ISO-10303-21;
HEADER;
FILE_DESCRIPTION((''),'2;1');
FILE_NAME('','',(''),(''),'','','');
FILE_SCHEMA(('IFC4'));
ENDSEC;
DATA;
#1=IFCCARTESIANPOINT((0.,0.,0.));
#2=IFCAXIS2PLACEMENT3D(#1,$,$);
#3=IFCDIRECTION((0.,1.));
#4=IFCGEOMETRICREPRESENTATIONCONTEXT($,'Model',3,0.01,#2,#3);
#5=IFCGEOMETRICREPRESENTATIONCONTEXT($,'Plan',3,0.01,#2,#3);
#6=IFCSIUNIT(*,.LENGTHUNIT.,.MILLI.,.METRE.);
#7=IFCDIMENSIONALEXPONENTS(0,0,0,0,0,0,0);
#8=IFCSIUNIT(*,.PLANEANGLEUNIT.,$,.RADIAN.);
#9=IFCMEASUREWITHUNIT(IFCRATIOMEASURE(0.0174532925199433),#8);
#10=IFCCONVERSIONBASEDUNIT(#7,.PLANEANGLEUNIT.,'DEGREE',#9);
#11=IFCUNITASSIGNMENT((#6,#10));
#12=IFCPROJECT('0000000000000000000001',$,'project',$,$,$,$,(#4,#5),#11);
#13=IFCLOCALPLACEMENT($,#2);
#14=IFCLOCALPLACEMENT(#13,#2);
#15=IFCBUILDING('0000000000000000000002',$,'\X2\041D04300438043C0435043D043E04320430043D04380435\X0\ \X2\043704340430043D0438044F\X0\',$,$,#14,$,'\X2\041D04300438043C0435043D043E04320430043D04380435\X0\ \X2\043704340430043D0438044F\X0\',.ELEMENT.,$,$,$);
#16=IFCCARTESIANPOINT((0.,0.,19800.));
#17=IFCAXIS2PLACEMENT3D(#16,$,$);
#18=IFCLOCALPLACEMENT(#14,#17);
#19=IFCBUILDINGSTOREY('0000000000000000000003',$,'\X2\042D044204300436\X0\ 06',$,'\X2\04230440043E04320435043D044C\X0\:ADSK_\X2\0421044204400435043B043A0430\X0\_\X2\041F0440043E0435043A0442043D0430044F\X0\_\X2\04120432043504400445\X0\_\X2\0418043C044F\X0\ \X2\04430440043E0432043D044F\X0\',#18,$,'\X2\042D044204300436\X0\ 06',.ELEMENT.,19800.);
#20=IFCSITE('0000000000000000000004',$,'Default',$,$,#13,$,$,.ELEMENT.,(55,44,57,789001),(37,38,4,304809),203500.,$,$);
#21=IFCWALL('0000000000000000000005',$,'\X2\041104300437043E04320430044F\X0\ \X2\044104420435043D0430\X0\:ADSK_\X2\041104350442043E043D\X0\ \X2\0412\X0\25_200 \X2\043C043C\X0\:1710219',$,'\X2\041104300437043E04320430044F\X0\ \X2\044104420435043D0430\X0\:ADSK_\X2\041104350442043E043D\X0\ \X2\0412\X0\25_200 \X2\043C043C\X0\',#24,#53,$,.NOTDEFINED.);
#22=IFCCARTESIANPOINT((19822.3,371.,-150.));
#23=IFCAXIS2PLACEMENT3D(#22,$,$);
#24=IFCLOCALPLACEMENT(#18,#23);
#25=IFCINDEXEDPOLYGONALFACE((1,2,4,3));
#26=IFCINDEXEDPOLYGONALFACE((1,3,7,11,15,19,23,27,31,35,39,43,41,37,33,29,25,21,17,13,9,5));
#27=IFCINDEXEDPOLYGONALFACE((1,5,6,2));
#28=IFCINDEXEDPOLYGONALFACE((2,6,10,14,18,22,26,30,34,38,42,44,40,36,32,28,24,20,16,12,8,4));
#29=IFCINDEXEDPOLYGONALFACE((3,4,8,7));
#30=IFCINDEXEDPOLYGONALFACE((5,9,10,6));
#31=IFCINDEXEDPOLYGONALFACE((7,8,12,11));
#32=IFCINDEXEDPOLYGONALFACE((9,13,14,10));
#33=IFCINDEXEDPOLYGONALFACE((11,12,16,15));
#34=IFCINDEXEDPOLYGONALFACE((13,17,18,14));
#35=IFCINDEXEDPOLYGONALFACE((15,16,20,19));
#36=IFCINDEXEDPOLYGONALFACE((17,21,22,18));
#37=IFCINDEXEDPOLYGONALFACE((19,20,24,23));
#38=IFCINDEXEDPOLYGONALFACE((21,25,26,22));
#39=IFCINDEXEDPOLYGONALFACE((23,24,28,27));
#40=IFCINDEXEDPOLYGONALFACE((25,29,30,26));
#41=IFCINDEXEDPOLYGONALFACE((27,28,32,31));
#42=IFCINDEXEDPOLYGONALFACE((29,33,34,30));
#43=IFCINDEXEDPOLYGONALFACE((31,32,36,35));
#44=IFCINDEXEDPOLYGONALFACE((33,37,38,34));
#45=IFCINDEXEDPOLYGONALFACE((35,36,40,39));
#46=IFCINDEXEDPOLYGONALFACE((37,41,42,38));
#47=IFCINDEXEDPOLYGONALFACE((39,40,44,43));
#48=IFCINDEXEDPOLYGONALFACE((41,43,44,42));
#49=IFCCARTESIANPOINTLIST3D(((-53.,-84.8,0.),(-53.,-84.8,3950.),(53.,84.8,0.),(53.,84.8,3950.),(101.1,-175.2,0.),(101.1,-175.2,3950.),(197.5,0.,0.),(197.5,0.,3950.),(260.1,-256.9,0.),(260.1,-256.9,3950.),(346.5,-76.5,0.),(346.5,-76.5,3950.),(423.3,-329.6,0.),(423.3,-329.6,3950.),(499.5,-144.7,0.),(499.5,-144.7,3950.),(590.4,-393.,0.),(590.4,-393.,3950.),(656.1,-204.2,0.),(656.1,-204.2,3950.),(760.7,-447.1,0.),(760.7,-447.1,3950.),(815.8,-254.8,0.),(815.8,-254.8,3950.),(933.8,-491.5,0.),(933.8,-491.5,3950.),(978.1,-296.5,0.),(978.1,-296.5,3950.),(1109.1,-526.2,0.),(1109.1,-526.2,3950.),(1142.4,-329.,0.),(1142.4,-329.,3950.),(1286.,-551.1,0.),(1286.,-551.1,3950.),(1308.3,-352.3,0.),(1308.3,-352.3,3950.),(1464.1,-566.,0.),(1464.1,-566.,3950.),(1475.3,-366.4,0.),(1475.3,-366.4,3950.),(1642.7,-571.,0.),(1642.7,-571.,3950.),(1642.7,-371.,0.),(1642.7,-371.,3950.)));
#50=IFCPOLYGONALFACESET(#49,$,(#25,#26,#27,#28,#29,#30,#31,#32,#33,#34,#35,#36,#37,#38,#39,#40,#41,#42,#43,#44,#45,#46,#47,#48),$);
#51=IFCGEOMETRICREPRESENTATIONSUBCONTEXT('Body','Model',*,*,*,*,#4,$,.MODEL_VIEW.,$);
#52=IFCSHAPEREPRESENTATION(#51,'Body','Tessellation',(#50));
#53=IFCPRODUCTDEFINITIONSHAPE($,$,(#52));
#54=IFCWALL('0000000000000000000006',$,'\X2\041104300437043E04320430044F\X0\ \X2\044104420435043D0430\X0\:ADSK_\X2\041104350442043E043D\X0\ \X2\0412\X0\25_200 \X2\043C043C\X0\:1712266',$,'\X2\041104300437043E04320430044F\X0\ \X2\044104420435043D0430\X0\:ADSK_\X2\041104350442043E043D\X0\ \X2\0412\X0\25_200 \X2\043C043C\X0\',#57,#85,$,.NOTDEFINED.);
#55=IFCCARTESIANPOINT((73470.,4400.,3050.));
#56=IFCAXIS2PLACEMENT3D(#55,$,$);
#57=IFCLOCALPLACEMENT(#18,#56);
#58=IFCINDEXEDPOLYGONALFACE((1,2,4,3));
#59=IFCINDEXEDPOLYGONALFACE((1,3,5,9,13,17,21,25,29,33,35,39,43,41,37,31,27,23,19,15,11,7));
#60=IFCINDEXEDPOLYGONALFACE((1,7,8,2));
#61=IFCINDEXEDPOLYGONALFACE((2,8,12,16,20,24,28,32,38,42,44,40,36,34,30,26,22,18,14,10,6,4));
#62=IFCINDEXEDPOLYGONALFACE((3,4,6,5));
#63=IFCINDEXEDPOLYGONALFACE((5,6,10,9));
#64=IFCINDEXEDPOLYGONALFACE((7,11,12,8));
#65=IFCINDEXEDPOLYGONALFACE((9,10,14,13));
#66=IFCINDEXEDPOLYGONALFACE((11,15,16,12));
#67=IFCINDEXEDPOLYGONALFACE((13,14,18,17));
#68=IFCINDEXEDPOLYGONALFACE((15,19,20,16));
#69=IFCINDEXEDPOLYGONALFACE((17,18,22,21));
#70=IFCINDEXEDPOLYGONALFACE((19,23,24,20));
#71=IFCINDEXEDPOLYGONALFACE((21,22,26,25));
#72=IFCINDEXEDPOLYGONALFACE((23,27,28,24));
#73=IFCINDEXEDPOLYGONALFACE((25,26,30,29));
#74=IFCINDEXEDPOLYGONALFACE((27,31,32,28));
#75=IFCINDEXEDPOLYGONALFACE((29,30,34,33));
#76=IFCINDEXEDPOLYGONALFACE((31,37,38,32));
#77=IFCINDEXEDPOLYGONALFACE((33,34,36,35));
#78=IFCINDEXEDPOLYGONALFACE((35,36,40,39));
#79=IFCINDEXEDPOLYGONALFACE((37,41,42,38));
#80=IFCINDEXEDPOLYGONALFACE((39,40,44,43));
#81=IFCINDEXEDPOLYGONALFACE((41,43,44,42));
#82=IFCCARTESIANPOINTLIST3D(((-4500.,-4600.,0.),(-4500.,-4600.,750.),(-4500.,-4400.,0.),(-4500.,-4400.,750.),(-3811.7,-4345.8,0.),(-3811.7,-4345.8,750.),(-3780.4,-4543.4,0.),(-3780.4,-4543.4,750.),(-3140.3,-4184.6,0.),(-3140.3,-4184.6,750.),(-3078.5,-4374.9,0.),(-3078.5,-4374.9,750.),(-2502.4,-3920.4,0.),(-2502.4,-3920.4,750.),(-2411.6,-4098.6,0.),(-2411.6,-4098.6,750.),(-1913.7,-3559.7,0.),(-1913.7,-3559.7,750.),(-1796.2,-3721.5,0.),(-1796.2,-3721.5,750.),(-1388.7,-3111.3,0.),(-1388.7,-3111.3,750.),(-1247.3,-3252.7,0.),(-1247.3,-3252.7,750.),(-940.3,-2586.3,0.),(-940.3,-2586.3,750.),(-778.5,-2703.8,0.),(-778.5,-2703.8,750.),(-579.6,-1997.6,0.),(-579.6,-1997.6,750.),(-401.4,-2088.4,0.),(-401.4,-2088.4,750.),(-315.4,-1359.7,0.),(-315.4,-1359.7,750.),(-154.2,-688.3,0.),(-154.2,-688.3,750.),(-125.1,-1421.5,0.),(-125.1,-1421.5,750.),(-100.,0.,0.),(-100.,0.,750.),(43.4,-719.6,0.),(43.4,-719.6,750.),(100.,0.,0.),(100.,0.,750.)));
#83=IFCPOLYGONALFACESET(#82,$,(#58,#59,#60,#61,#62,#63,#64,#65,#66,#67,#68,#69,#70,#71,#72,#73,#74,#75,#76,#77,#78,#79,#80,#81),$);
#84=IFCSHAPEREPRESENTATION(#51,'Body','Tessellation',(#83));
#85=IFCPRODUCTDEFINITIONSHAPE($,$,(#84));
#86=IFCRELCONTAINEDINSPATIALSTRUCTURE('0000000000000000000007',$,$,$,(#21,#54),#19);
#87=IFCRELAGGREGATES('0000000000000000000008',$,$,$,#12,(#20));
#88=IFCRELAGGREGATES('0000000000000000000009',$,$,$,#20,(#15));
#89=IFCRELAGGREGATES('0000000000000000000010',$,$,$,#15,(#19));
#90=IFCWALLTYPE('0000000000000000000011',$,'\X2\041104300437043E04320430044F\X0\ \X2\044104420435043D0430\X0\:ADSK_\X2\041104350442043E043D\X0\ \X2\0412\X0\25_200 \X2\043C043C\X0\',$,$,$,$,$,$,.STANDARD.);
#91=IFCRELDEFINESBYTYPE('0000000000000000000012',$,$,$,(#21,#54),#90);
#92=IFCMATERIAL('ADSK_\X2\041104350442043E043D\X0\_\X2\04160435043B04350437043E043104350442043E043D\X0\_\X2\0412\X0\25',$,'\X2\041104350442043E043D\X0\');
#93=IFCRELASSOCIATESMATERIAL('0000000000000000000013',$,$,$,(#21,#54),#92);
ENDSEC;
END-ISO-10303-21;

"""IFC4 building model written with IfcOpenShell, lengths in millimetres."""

from ifc_helpers import new_model, entity, si_unit, converted_unit, direction, frame, origin, place, context, subcontext, project, spatial, indexed_curve, outline, extrude, material, type_object, element, save


model = new_model("IFC4")

# Units and contexts
model_context = context("Model", 3, precision=0.01, world=origin(), true_north=direction((0.0, 1.0)))
plan_context = context("Plan", 3, precision=0.01, world=origin(), true_north=direction((0.0, 1.0)))
body_context = subcontext(model_context, "Body", "Model", "MODEL_VIEW")
ifc_project = project(units=[si_unit("LENGTHUNIT", "METRE", prefix="MILLI"), converted_unit("PLANEANGLEUNIT", "DEGREE", entity("IfcRatioMeasure", 0.0174532925199433), si_unit("PLANEANGLEUNIT", "RADIAN"), dimensions=[0, 0, 0, 0, 0, 0, 0])], contexts=[model_context, plan_context])

# Site, building, storey
site_placement = place(None, origin())
site = spatial("IfcSite", under=ifc_project, at=site_placement, Name="Default", CompositionType="ELEMENT", RefLatitude=(55, 44, 57, 789001), RefLongitude=(37, 38, 4, 304809), RefElevation=203500.0)
building_placement = place(site_placement, origin())
building = spatial("IfcBuilding", under=site, at=building_placement, Name="Наименование здания", LongName="Наименование здания", CompositionType="ELEMENT")
storey_placement = place(building_placement, frame((0.0, 0.0, 19800.0)))
storey = spatial("IfcBuildingStorey", under=building, at=storey_placement, Name="Этаж 06", ObjectType="Уровень:ADSK_Стрелка_Проектная_Вверх_Имя уровня", LongName="Этаж 06", CompositionType="ELEMENT", Elevation=19800.0)

# Walls
ifc_material = material(Name="ADSK_Бетон_Железобетон_В25", Category="Бетон")
wall_type_1 = type_object("IfcWallType", Name="Базовая стена:ADSK_Бетон В25_200 мм", PredefinedType="STANDARD")
wall_1_placement = place(storey_placement, frame((19822.3, 371.0, -150.0)))
element("IfcWall", 1, at=wall_1_placement, inside=storey, type_object=wall_type_1, material=ifc_material, Name="Базовая стена:ADSK_Бетон В25_200 мм:1710219", ObjectType="Базовая стена:ADSK_Бетон В25_200 мм", PredefinedType="NOTDEFINED", context=body_context, shape_type="SweptSolid", body=[
    extrude(outline(indexed_curve([(1642.7, -371.0), (1475.3, -366.4), (1308.3, -352.3), (1142.4, -329.0), (978.1, -296.5), (815.8, -254.8), (656.1, -204.2), (499.5, -144.7), (346.5, -76.5), (197.5, 0.0), (53.0, 84.8), (-53.0, -84.8), (101.1, -175.2), (260.1, -256.9), (423.3, -329.6), (590.4, -393.0), (760.7, -447.1), (933.8, -491.5), (1109.1, -526.2), (1286.0, -551.1), (1464.1, -566.0), (1642.7, -571.0), (1642.7, -371.0)], self_intersect=False)), origin(), (0.0, 0.0, 1.0), 3950.0),
])
wall_2_placement = place(storey_placement, frame((73470.0, 4400.0, 3050.0)))
element("IfcWall", 2, at=wall_2_placement, inside=storey, type_object=wall_type_1, material=ifc_material, Name="Базовая стена:ADSK_Бетон В25_200 мм:1712266", ObjectType="Базовая стена:ADSK_Бетон В25_200 мм", PredefinedType="NOTDEFINED", context=body_context, shape_type="SweptSolid", body=[
    extrude(outline(indexed_curve([(-4500.0, -4600.0), (-3780.4, -4543.4), (-3078.5, -4374.9), (-2411.6, -4098.6), (-1796.2, -3721.5), (-1247.3, -3252.7), (-778.5, -2703.8), (-401.4, -2088.4), (-125.1, -1421.5), (43.4, -719.6), (100.0, 0.0), (-100.0, 0.0), (-154.2, -688.3), (-315.4, -1359.7), (-579.6, -1997.6), (-940.3, -2586.3), (-1388.7, -3111.3), (-1913.7, -3559.7), (-2502.4, -3920.4), (-3140.3, -4184.6), (-3811.7, -4345.8), (-4500.0, -4400.0), (-4500.0, -4600.0)], self_intersect=False)), origin(), (0.0, 0.0, 1.0), 750.0),
])

save(model, "model.ifc")
